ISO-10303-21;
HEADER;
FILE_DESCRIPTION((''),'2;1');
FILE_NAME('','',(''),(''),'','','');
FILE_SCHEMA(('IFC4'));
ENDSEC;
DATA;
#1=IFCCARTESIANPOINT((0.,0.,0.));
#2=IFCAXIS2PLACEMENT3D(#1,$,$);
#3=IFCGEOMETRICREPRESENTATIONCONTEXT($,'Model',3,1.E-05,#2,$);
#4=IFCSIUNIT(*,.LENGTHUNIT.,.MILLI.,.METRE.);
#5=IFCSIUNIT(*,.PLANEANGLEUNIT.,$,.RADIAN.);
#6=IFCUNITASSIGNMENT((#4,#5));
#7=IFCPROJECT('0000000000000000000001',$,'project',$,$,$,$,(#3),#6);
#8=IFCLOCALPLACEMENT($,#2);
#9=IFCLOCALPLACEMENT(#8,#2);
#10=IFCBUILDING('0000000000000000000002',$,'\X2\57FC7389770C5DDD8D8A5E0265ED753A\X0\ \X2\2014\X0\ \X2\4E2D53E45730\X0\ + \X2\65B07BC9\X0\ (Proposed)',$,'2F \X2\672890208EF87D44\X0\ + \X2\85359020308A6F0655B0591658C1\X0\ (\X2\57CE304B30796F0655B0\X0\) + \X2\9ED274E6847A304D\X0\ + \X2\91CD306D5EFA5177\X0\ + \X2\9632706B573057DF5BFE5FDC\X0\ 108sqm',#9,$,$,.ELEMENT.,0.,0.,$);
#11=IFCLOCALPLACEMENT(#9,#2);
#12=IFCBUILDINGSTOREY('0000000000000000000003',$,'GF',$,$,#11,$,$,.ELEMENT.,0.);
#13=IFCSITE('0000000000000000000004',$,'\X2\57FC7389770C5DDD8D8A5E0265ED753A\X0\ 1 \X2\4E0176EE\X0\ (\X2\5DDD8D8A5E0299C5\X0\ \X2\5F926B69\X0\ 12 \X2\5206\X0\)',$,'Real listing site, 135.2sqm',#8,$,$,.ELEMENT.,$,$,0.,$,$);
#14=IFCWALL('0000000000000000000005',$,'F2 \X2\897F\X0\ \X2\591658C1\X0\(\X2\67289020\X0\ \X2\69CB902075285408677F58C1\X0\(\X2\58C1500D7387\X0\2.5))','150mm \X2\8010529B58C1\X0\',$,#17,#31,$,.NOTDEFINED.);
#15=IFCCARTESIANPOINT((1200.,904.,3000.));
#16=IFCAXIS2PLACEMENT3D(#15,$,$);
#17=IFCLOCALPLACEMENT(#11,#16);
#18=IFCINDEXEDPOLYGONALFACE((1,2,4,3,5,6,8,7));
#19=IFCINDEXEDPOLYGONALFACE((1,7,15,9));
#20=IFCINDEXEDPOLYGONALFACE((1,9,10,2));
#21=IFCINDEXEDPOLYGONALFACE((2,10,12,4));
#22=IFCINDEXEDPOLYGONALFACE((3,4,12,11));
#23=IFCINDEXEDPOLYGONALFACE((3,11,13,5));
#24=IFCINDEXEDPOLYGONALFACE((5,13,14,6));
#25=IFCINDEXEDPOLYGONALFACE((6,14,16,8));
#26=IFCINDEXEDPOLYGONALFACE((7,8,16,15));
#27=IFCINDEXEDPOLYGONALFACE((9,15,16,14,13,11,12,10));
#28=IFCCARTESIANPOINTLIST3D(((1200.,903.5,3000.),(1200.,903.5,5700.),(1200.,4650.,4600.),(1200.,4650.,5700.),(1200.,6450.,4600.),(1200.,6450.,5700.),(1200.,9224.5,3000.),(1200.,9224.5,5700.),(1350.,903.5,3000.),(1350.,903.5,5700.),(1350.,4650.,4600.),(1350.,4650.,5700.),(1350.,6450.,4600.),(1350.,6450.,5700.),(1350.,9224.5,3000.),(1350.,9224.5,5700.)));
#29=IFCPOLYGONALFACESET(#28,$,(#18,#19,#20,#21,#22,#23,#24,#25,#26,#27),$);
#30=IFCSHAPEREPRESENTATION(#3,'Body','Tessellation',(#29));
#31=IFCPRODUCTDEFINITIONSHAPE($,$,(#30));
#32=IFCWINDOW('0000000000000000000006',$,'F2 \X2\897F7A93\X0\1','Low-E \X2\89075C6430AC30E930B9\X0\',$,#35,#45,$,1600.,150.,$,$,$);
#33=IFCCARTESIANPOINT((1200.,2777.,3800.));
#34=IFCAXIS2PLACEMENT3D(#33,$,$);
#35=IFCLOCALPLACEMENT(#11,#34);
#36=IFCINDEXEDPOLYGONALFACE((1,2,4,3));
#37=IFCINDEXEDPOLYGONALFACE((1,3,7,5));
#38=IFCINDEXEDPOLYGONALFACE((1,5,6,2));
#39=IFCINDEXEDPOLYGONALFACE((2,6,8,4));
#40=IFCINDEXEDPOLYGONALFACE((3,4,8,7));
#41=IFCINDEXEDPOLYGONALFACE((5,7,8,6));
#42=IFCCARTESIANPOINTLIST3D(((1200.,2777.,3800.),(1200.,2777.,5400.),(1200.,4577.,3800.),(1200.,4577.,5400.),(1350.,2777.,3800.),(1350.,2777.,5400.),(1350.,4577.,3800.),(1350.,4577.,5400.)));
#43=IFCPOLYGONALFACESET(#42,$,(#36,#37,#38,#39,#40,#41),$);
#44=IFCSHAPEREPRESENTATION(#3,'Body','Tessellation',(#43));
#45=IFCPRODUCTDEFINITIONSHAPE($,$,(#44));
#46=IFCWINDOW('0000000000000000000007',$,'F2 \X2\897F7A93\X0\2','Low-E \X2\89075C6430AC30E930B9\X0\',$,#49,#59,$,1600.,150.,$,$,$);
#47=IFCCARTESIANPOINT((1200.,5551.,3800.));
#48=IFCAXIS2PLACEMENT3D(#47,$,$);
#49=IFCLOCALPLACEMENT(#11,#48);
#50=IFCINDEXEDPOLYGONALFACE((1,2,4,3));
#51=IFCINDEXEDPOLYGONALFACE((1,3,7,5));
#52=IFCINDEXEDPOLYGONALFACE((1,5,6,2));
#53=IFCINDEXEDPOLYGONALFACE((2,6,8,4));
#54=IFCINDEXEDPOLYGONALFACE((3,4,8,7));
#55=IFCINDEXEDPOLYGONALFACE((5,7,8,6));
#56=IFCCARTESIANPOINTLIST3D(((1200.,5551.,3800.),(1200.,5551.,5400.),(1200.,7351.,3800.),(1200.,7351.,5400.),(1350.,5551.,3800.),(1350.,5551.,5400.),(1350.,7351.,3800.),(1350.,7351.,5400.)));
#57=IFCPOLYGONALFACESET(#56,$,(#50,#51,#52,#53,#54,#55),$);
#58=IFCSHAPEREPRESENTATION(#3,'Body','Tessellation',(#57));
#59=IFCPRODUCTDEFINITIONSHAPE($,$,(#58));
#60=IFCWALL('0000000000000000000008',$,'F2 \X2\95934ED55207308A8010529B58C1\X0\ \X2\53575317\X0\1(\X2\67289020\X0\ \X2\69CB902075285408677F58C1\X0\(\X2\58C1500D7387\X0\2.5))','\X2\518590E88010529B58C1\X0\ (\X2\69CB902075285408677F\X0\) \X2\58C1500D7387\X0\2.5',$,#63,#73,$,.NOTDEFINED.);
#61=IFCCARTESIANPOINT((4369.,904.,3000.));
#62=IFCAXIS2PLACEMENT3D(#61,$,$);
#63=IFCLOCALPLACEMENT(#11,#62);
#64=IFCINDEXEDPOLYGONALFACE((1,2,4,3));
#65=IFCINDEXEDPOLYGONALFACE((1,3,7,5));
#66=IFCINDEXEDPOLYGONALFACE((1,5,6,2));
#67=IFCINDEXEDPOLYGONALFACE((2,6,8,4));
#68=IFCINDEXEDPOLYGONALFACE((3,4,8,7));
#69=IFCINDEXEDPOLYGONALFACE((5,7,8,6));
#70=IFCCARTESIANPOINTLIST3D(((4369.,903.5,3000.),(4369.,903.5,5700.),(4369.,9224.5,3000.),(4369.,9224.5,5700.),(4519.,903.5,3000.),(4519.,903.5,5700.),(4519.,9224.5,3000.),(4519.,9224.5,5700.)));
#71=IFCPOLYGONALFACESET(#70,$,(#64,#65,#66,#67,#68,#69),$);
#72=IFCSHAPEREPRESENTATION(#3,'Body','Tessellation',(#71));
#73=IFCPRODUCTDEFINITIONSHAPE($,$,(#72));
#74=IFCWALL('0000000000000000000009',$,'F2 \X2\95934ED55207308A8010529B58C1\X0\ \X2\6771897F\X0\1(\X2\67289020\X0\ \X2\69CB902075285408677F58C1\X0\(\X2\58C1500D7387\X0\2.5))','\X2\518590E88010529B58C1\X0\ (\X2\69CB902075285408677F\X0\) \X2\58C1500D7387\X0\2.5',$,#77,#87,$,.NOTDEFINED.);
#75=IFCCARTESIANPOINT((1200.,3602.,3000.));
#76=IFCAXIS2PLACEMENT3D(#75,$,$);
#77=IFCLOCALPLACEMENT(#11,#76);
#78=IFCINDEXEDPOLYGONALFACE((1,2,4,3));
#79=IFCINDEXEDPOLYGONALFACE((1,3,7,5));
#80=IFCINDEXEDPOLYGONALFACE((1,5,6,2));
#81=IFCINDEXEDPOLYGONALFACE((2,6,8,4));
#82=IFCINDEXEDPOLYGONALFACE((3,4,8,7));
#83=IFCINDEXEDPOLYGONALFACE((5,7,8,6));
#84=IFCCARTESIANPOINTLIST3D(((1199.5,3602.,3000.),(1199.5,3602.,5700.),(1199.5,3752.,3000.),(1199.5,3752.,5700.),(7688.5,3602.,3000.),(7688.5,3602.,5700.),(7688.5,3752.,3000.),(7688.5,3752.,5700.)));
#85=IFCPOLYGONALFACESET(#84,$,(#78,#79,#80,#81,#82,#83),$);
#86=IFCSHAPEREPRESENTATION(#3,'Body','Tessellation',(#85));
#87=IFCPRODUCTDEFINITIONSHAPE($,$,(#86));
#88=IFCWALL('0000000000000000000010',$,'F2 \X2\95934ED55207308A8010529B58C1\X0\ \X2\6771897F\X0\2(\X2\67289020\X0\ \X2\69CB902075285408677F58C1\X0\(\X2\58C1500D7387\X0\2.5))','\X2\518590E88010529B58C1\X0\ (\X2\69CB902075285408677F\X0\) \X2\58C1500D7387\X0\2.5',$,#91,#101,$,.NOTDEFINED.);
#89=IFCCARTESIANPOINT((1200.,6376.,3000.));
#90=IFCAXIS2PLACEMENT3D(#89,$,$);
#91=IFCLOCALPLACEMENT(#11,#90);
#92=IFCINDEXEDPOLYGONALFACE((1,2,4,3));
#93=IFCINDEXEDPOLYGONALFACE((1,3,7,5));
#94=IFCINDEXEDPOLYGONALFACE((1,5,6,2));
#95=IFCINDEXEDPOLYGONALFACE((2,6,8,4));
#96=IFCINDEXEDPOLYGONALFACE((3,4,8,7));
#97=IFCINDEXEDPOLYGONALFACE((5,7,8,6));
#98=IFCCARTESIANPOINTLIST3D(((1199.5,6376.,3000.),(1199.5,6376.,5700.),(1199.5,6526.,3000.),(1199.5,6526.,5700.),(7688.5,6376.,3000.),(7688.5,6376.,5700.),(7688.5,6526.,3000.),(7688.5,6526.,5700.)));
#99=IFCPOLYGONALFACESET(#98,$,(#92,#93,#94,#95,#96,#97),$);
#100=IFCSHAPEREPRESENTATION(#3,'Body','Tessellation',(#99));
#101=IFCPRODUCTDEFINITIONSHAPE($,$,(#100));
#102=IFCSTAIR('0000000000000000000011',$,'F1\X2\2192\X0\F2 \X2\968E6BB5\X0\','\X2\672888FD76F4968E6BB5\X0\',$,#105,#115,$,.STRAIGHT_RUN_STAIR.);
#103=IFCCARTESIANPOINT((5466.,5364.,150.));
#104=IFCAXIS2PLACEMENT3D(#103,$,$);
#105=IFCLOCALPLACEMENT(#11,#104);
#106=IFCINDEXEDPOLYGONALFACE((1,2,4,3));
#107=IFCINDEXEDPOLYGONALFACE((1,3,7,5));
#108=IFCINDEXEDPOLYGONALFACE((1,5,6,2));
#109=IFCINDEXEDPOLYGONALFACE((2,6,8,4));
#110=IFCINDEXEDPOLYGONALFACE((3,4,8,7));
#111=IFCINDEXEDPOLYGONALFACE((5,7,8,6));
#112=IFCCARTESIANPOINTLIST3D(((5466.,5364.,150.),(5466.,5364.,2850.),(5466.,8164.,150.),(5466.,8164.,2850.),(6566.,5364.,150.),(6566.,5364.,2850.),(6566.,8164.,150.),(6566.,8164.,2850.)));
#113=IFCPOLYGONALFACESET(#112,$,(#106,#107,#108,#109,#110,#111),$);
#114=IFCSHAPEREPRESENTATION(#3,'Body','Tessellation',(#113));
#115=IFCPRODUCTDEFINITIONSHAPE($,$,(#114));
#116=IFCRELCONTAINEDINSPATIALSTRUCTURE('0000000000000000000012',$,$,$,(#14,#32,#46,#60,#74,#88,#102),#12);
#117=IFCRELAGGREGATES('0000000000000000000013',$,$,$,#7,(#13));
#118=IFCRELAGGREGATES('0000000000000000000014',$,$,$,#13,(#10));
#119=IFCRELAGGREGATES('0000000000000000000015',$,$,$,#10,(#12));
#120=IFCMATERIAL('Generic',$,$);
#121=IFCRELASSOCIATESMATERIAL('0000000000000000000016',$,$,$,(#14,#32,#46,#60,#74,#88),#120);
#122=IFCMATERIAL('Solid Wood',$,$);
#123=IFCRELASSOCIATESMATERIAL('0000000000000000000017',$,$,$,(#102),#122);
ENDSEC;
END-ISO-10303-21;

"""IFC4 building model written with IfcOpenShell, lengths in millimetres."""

from ifc_helpers import new_model, si_unit, frame, frame_2d, origin, place, context, project, spatial, rectangle, extrude, material, element, fill, save


model = new_model("IFC4")

# Units and contexts
model_context = context("Model", 3, precision=1e-05, world=origin())
ifc_project = project(units=[si_unit("LENGTHUNIT", "METRE", prefix="MILLI"), si_unit("PLANEANGLEUNIT", "RADIAN")], contexts=[model_context])

# Site, building, storey
site_placement = place(None, origin())
site = spatial("IfcSite", under=ifc_project, at=site_placement, Name="埼玉県川越市旭町 1 丁目 (川越市駅 徒歩 12 分)", ObjectType="Real listing site, 135.2sqm", CompositionType="ELEMENT", RefElevation=0.0)
building_placement = place(site_placement, origin())
building = spatial("IfcBuilding", under=site, at=building_placement, Name="埼玉県川越市旭町 — 中古地 + 新築 (Proposed)", ObjectType="2F 木造軸組 + 蔵造り漆喰外壁 (城かべ漆喰) + 黒瓦葺き + 重ね建具 + 防火地域対応 108sqm", CompositionType="ELEMENT", ElevationOfRefHeight=0.0, ElevationOfTerrain=0.0)
storey_placement = place(building_placement, origin())
storey = spatial("IfcBuildingStorey", under=building, at=storey_placement, Name="GF", CompositionType="ELEMENT", Elevation=0.0)

# Shared definitions
ifc_material_1 = material(Name="Generic")

# Wall, openings, windows
wall_1_placement = place(storey_placement, frame((1200.0, 904.0, 3000.0)))
wall_1 = element("IfcWall", 1, at=wall_1_placement, inside=storey, material=ifc_material_1, Name="F2 西 外壁(木造 構造用合板壁(壁倍率2.5))", Description="150mm 耐力壁", PredefinedType="NOTDEFINED", context=model_context, shape_type="SweptSolid", body=[
    extrude(rectangle(XDim=150.0, YDim=8321.0, at=frame_2d((75.0, 4160.0))), frame((1200.0, 904.0, 3000.0)), (0.0, 0.0, 1.0), 2700.0),
])
opening_1_placement = place(storey_placement, frame((1200.0, 2777.0, 3800.0)))
opening_1 = element("IfcOpeningElement", 2, at=opening_1_placement, cuts=wall_1, PredefinedType="NOTDEFINED", context=model_context, shape_type="SweptSolid", body=[
    extrude(rectangle(XDim=150.0, YDim=1800.0, at=frame_2d((75.0, 900.0))), frame((1200.0, 2777.0, 3800.0)), (0.0, 0.0, 1.0), 1600.0),
])
opening_2_placement = place(storey_placement, frame((1200.0, 5551.0, 3800.0)))
opening_2 = element("IfcOpeningElement", 3, at=opening_2_placement, cuts=wall_1, PredefinedType="NOTDEFINED", context=model_context, shape_type="SweptSolid", body=[
    extrude(rectangle(XDim=150.0, YDim=1800.0, at=frame_2d((75.0, 900.0))), frame((1200.0, 5551.0, 3800.0)), (0.0, 0.0, 1.0), 1600.0),
])
window_1_placement = place(storey_placement, frame((1200.0, 2777.0, 3800.0)))
window_1 = element("IfcWindow", 4, at=window_1_placement, inside=storey, material=ifc_material_1, Name="F2 西窓1", Description="Low-E 複層ガラス", OverallHeight=1600.0, OverallWidth=150.0, context=model_context, shape_type="SweptSolid", body=[
    extrude(rectangle(XDim=150.0, YDim=1800.0, at=frame_2d((75.0, 900.0))), frame((1200.0, 2777.0, 3800.0)), (0.0, 0.0, 1.0), 1600.0),
])
fill(opening_1, window_1)
window_2_placement = place(storey_placement, frame((1200.0, 5551.0, 3800.0)))
window_2 = element("IfcWindow", 5, at=window_2_placement, inside=storey, material=ifc_material_1, Name="F2 西窓2", Description="Low-E 複層ガラス", OverallHeight=1600.0, OverallWidth=150.0, context=model_context, shape_type="SweptSolid", body=[
    extrude(rectangle(XDim=150.0, YDim=1800.0, at=frame_2d((75.0, 900.0))), frame((1200.0, 5551.0, 3800.0)), (0.0, 0.0, 1.0), 1600.0),
])
fill(opening_2, window_2)

# Walls
wall_2_placement = place(storey_placement, frame((4369.0, 904.0, 3000.0)))
element("IfcWall", 6, at=wall_2_placement, inside=storey, material=ifc_material_1, Name="F2 間仕切り耐力壁 南北1(木造 構造用合板壁(壁倍率2.5))", Description="内部耐力壁 (構造用合板) 壁倍率2.5", PredefinedType="NOTDEFINED", context=model_context, shape_type="SweptSolid", body=[
    extrude(rectangle(XDim=150.0, YDim=8321.0, at=frame_2d((75.0, 4160.0))), frame((4369.0, 904.0, 3000.0)), (0.0, 0.0, 1.0), 2700.0),
])
wall_3_placement = place(storey_placement, frame((1200.0, 3602.0, 3000.0)))
element("IfcWall", 7, at=wall_3_placement, inside=storey, material=ifc_material_1, Name="F2 間仕切り耐力壁 東西1(木造 構造用合板壁(壁倍率2.5))", Description="内部耐力壁 (構造用合板) 壁倍率2.5", PredefinedType="NOTDEFINED", context=model_context, shape_type="SweptSolid", body=[
    extrude(rectangle(XDim=6489.0, YDim=150.0, at=frame_2d((3244.0, 75.0))), frame((1200.0, 3602.0, 3000.0)), (0.0, 0.0, 1.0), 2700.0),
])
wall_4_placement = place(storey_placement, frame((1200.0, 6376.0, 3000.0)))
element("IfcWall", 8, at=wall_4_placement, inside=storey, material=ifc_material_1, Name="F2 間仕切り耐力壁 東西2(木造 構造用合板壁(壁倍率2.5))", Description="内部耐力壁 (構造用合板) 壁倍率2.5", PredefinedType="NOTDEFINED", context=model_context, shape_type="SweptSolid", body=[
    extrude(rectangle(XDim=6489.0, YDim=150.0, at=frame_2d((3244.0, 75.0))), frame((1200.0, 6376.0, 3000.0)), (0.0, 0.0, 1.0), 2700.0),
])

# Stair
ifc_material_2 = material(Name="Solid Wood")
stair_placement = place(storey_placement, frame((5466.0, 5364.0, 150.0)))
element("IfcStair", 9, at=stair_placement, inside=storey, material=ifc_material_2, Name="F1→F2 階段", Description="木製直階段", PredefinedType="STRAIGHT_RUN_STAIR", context=model_context, shape_type="SweptSolid", body=[
    extrude(rectangle(XDim=1100.0, YDim=2800.0, at=frame_2d((550.0, 1400.0))), frame((5466.0, 5364.0, 150.0)), (0.0, 0.0, 1.0), 2700.0),
])

save(model, "model.ifc")
